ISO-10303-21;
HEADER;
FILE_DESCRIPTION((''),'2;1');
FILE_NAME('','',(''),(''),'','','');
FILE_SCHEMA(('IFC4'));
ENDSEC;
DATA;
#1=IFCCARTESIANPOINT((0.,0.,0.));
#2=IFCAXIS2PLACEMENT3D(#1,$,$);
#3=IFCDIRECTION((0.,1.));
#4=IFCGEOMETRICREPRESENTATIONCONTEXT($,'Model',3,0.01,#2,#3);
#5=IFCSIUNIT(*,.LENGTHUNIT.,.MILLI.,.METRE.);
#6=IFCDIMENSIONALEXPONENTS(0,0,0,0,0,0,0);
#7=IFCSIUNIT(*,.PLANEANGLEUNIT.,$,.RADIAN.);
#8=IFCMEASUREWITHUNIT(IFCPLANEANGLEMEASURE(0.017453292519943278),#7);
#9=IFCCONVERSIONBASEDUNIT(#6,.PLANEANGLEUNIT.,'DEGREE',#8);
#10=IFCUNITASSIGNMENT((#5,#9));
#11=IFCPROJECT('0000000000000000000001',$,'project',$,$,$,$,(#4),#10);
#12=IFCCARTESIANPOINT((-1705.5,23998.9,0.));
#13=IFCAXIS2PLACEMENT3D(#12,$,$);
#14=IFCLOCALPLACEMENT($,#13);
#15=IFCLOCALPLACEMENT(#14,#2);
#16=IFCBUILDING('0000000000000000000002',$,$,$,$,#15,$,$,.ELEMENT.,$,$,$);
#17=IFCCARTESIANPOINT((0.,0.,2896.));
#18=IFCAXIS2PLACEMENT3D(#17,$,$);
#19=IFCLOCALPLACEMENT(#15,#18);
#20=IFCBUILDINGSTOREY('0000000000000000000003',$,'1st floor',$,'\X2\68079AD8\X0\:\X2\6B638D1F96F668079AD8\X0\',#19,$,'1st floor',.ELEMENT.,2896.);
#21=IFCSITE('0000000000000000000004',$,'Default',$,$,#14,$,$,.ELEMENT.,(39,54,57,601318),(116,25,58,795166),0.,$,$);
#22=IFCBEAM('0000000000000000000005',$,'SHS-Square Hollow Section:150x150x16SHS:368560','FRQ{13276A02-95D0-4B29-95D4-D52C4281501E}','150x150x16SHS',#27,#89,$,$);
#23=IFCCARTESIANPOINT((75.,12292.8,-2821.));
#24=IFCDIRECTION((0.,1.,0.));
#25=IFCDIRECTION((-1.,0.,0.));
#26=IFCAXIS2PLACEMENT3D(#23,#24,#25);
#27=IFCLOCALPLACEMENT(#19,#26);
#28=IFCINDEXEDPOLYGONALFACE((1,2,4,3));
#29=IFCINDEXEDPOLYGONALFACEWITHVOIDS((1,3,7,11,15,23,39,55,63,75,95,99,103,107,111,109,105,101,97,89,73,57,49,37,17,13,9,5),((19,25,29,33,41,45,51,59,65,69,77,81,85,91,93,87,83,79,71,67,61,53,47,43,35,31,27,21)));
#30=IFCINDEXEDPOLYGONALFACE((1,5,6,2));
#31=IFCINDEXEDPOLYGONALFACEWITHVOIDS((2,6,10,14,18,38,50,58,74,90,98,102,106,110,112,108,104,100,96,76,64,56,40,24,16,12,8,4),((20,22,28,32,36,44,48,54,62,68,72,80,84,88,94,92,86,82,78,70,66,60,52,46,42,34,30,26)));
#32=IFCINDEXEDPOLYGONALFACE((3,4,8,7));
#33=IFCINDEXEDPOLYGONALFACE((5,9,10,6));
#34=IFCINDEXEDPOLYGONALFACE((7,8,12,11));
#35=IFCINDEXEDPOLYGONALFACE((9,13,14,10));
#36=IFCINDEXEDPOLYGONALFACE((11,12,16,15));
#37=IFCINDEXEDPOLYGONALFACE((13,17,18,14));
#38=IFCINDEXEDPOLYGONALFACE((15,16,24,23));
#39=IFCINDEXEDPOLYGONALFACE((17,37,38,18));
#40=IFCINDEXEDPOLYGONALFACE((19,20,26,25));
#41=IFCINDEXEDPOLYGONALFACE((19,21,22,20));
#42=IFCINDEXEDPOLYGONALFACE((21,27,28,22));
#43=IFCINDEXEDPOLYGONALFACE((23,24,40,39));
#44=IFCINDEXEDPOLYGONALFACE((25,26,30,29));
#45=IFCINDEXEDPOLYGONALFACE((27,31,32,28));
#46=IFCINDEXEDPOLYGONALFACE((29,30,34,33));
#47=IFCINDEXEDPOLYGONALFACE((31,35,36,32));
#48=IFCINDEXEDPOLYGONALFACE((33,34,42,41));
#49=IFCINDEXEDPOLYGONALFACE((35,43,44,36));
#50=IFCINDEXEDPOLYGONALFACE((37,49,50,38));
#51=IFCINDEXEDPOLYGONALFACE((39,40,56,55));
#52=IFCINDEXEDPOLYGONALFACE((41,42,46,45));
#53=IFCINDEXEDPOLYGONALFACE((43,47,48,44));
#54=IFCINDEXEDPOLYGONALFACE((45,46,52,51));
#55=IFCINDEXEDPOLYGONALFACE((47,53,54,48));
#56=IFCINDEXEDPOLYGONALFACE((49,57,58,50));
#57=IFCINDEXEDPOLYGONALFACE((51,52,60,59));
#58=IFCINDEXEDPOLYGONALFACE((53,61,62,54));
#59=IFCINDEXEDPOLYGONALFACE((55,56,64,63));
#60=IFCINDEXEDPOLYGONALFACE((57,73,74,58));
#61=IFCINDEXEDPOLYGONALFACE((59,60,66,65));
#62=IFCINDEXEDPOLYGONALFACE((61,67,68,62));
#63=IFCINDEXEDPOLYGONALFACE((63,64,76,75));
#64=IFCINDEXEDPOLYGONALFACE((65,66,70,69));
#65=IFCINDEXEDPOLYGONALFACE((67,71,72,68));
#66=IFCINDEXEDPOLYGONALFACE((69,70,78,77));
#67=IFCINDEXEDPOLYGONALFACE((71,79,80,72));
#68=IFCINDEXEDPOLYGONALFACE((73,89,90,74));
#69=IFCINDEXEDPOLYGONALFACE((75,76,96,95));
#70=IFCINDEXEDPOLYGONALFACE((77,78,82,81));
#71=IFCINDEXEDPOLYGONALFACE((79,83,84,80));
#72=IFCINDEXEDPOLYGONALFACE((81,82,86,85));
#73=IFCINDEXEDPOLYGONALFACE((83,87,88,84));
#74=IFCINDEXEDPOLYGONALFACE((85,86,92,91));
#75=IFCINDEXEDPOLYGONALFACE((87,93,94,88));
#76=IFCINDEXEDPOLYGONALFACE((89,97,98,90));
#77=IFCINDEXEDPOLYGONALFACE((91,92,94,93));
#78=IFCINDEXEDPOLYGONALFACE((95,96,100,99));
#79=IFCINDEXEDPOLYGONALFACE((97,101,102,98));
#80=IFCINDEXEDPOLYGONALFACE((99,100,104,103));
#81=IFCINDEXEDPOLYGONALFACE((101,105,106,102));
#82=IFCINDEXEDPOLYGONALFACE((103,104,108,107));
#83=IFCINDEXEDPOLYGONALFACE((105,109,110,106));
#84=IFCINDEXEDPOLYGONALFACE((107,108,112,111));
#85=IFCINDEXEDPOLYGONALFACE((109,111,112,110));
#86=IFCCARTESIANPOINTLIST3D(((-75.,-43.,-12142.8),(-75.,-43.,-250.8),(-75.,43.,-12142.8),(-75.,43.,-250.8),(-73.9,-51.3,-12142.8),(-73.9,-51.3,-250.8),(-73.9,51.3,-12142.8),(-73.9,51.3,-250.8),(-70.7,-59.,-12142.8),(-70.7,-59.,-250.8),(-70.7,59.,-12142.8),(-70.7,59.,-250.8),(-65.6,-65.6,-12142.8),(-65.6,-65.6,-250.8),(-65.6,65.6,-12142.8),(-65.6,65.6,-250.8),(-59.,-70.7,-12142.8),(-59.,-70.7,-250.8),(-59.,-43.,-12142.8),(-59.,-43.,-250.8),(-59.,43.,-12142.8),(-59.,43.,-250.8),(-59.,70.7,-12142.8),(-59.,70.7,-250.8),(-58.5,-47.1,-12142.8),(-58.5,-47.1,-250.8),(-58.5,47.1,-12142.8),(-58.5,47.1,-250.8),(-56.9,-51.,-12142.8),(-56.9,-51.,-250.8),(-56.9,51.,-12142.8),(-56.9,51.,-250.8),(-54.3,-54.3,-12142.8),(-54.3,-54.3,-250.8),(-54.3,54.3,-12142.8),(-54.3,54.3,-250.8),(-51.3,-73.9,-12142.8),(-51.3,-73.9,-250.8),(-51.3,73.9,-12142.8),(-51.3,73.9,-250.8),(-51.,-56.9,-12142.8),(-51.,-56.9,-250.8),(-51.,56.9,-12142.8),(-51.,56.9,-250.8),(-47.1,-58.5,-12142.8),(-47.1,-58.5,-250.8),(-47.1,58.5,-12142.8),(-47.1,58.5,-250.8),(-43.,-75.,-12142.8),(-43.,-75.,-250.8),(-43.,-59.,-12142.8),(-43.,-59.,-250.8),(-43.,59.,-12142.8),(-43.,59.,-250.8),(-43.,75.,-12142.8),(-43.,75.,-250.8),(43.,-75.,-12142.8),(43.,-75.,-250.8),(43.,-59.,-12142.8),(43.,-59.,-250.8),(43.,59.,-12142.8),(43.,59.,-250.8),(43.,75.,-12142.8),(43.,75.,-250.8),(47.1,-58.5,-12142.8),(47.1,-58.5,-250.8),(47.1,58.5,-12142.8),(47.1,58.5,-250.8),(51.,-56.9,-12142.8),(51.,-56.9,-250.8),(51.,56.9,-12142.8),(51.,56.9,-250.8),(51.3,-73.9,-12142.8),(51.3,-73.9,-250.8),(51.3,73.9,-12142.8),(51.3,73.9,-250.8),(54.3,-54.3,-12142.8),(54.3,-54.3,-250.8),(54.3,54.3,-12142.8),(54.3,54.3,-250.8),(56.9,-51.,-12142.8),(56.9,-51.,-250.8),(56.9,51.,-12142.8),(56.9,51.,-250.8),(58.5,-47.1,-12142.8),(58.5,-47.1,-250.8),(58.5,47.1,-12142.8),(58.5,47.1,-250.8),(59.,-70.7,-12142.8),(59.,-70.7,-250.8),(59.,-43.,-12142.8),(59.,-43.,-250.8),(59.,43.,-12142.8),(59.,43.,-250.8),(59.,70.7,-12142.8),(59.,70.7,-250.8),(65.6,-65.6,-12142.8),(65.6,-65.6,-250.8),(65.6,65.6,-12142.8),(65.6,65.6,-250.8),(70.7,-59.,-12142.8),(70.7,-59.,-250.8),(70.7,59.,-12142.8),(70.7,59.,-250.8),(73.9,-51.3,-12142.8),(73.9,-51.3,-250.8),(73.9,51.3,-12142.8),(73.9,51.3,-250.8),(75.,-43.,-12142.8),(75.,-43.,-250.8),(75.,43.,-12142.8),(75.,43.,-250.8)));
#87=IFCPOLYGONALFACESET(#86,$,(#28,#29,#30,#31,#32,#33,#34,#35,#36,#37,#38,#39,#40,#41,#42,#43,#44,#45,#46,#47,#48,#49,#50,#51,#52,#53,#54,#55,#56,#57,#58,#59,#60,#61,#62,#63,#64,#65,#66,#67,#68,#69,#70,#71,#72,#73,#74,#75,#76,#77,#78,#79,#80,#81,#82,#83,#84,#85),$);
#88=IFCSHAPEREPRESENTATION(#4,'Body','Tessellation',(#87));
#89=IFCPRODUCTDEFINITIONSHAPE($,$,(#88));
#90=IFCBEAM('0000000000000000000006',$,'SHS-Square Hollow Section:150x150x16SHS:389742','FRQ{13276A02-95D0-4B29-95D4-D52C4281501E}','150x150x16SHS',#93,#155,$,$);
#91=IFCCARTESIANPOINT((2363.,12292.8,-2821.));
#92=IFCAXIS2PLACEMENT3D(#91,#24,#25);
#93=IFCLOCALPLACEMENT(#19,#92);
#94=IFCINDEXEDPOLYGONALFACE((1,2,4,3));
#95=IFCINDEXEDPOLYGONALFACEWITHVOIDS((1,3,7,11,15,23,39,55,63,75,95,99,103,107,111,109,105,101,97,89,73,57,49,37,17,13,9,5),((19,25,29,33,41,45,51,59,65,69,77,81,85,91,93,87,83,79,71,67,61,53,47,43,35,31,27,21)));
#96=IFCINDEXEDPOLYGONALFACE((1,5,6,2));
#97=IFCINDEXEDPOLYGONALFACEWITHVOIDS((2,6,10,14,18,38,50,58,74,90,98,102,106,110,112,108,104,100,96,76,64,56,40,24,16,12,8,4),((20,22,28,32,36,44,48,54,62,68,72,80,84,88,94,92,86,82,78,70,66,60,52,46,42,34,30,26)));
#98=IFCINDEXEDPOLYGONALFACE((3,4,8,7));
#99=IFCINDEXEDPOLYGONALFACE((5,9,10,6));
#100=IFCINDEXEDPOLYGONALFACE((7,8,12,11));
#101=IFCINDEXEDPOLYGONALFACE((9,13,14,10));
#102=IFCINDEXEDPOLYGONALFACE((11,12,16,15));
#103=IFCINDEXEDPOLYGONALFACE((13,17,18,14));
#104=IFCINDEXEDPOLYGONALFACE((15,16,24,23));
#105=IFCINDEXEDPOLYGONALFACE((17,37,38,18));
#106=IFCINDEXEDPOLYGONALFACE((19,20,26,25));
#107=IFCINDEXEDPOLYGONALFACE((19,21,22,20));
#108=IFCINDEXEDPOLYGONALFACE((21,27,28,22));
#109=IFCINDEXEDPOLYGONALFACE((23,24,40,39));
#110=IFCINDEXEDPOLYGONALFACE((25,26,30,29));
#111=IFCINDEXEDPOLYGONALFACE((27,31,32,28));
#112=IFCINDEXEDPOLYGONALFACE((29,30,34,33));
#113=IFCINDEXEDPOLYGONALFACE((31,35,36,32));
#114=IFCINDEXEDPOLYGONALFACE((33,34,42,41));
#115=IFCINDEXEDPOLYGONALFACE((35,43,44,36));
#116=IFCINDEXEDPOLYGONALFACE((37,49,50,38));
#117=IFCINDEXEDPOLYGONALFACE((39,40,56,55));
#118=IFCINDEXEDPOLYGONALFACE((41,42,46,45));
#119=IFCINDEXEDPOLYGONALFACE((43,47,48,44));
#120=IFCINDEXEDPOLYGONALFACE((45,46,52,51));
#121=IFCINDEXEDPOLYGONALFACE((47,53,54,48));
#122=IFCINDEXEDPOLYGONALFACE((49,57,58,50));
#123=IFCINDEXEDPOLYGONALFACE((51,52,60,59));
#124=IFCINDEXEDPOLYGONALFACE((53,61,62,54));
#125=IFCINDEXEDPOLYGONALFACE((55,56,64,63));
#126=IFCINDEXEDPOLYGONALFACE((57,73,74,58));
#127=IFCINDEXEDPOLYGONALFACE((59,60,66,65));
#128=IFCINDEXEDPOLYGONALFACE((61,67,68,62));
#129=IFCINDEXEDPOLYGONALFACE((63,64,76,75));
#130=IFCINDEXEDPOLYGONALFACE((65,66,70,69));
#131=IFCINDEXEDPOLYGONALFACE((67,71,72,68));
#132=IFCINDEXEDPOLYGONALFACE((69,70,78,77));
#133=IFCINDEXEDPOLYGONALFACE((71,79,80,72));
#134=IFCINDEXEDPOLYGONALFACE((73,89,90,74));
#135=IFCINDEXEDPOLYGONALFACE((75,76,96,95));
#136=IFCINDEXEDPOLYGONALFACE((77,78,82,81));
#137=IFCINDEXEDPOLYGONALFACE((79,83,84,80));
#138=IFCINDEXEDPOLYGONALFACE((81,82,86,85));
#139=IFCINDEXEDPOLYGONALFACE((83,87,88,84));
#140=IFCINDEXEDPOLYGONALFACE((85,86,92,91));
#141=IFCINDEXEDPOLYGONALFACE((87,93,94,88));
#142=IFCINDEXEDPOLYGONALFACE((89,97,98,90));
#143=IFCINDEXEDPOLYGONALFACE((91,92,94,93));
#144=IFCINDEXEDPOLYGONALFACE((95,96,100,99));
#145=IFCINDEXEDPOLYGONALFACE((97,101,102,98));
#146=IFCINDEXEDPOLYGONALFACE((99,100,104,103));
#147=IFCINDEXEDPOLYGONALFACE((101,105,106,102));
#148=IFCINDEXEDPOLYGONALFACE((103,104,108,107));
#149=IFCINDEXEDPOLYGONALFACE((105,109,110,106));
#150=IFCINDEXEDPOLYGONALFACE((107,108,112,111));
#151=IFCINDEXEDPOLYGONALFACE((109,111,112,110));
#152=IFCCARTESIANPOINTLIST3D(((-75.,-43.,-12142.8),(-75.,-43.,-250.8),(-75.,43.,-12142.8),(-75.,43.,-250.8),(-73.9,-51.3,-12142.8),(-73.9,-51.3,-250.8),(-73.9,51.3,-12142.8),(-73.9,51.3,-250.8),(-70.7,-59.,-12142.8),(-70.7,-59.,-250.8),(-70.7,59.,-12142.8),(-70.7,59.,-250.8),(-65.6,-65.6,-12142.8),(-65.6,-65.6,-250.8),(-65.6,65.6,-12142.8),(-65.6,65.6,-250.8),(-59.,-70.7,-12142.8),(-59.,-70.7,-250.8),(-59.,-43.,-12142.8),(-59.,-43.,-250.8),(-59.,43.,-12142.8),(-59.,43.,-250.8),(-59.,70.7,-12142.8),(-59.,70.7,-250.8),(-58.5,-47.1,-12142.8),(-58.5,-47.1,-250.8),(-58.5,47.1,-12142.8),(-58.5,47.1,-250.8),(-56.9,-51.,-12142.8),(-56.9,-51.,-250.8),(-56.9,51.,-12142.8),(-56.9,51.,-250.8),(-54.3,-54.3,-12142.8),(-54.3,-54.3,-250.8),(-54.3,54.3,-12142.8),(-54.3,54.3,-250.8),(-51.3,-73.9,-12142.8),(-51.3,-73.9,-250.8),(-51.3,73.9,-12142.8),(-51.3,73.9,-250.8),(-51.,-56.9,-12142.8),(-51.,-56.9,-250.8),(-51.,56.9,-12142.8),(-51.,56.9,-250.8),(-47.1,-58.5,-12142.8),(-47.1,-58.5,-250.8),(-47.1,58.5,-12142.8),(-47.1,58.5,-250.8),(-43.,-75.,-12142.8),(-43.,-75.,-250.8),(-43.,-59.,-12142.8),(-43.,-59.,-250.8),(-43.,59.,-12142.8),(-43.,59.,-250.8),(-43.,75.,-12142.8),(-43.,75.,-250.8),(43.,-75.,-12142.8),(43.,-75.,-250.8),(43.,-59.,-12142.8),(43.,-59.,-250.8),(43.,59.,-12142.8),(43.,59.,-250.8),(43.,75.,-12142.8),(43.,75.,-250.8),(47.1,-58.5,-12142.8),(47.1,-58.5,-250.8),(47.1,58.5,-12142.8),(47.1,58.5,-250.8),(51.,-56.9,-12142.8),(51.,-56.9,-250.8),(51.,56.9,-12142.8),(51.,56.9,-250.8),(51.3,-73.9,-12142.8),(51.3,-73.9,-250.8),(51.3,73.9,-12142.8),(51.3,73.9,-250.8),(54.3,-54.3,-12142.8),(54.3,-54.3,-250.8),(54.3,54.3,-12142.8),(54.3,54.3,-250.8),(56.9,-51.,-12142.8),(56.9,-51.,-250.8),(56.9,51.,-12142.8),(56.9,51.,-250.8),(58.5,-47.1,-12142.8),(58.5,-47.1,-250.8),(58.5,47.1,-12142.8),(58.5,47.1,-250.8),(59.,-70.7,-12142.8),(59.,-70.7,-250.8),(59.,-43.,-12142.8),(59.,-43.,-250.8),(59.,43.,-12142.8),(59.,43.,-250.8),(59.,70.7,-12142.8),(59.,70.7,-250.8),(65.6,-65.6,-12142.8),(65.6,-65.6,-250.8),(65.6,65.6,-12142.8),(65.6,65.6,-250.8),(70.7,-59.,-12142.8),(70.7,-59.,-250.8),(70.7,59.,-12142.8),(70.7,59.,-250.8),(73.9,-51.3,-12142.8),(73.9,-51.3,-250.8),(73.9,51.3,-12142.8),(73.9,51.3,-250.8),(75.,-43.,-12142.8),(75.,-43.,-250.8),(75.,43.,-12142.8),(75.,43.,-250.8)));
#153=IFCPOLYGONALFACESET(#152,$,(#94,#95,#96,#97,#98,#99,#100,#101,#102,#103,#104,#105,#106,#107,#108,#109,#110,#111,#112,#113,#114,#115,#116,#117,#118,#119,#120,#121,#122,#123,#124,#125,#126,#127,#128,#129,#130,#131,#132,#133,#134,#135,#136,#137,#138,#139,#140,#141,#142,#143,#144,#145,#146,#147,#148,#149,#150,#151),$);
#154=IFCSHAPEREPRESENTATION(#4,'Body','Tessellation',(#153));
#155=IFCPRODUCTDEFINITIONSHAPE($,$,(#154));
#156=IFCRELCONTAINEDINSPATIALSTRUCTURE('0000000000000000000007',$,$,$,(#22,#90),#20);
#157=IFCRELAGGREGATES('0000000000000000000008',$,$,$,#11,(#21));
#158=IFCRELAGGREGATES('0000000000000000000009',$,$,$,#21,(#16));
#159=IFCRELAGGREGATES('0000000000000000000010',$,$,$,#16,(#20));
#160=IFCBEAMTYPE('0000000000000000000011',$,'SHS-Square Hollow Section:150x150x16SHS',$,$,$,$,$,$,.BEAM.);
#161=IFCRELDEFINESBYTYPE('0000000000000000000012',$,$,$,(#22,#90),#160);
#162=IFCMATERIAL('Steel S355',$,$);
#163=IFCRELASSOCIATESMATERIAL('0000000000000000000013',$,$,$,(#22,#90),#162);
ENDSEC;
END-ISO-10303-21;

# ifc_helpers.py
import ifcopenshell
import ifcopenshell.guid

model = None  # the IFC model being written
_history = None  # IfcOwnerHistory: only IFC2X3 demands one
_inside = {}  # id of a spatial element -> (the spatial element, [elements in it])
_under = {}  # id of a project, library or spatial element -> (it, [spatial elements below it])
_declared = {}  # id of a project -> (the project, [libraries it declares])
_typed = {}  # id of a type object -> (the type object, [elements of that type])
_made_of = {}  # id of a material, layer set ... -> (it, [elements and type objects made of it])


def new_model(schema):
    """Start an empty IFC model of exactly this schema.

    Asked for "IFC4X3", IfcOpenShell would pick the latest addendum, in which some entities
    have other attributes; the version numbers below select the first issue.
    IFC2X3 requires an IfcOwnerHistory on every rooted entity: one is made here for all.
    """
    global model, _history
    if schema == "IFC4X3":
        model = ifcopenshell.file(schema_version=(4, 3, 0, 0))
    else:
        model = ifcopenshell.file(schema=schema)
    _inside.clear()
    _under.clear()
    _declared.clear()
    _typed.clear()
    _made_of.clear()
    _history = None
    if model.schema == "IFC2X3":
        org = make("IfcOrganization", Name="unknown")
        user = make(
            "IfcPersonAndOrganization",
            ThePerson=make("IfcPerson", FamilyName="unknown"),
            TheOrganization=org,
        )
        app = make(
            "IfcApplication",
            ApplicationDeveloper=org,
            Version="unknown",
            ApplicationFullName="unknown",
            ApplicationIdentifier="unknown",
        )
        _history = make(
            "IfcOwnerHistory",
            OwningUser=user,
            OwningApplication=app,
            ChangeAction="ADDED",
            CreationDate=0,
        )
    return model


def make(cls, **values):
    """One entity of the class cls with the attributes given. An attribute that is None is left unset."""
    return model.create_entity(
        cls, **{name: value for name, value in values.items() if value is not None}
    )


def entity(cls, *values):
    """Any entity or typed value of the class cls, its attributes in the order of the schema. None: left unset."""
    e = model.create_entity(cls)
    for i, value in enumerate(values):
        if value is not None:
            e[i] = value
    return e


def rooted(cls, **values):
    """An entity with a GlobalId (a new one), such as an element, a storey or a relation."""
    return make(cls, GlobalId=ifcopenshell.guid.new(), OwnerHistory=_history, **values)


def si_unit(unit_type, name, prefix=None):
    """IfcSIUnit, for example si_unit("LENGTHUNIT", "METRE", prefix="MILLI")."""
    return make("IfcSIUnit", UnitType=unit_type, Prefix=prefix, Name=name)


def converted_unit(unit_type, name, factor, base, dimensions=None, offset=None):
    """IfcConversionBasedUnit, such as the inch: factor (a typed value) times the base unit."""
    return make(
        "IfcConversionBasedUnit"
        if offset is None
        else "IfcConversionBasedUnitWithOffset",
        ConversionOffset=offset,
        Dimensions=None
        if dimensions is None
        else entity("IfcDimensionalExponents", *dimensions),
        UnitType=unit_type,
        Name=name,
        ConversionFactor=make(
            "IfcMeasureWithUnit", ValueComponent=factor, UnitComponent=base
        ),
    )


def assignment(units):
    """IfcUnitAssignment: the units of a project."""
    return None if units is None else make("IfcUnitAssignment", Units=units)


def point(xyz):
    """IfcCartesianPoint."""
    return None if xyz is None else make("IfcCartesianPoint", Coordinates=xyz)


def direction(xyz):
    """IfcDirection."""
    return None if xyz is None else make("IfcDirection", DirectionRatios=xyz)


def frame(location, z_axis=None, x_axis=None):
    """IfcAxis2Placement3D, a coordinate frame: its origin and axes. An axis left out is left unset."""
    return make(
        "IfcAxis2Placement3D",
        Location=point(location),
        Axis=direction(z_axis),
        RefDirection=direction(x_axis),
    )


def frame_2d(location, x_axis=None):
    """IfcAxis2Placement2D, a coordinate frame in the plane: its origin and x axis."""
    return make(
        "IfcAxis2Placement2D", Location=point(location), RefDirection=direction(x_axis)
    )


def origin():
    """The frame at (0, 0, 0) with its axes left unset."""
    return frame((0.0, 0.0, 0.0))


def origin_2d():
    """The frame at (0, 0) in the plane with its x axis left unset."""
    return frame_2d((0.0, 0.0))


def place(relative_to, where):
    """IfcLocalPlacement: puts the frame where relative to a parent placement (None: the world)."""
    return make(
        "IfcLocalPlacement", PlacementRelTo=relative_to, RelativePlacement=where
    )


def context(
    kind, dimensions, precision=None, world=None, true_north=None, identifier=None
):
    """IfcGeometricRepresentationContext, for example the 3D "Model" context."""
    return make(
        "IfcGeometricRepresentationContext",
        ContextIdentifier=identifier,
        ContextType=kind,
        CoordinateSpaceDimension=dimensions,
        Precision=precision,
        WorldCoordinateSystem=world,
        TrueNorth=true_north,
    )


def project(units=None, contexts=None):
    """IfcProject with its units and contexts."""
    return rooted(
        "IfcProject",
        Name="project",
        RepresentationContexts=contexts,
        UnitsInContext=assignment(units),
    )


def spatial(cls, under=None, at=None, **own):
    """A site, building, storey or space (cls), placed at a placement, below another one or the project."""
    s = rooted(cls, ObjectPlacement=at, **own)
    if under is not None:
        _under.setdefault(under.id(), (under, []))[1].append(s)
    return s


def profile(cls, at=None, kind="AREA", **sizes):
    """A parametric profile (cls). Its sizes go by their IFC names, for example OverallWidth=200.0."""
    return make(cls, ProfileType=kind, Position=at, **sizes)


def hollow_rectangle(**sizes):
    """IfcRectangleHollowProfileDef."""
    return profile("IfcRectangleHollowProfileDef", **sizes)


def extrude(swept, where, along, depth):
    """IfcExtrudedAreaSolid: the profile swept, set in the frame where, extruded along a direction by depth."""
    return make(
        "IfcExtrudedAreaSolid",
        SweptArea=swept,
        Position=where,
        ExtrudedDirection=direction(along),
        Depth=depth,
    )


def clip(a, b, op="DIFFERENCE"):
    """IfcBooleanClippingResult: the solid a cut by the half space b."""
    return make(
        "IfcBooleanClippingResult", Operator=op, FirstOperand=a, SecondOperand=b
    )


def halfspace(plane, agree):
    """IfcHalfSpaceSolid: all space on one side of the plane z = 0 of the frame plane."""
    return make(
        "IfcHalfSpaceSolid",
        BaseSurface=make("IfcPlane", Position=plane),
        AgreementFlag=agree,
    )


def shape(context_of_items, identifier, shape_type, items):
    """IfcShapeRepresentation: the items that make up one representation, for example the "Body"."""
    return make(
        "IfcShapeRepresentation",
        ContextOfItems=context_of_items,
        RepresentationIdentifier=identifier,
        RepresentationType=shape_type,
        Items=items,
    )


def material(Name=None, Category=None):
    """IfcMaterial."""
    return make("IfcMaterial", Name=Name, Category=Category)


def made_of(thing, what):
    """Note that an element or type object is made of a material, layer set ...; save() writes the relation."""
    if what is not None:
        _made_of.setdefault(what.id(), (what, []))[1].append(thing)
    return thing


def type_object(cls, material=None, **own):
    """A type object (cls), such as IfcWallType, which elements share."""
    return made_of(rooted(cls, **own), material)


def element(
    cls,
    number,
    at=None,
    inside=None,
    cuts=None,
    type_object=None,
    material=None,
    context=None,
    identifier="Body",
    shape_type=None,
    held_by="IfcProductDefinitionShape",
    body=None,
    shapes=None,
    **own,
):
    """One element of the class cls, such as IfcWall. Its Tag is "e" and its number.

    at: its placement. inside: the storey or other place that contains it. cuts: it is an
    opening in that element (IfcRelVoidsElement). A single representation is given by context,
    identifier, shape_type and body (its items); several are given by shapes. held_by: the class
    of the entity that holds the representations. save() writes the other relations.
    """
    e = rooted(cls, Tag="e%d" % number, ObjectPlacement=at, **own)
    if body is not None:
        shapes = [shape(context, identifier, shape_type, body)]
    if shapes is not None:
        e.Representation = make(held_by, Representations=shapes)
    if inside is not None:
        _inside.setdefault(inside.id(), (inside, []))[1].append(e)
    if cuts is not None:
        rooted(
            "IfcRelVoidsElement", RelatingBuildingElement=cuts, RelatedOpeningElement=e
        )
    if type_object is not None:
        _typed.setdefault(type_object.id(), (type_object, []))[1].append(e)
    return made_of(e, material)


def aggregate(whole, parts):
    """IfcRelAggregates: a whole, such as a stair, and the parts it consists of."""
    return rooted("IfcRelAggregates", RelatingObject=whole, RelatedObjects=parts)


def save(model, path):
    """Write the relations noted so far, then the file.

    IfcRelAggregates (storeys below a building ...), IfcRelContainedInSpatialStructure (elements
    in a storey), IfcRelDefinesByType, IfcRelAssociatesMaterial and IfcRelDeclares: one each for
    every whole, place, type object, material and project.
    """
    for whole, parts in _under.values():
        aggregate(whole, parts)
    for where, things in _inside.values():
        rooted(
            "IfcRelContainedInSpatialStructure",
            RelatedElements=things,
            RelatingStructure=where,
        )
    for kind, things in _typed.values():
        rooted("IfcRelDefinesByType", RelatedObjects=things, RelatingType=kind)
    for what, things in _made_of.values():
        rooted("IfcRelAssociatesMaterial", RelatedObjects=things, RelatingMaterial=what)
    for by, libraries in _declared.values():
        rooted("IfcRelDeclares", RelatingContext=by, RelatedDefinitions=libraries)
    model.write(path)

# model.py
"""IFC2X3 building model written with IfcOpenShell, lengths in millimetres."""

from ifc_helpers import new_model, entity, si_unit, converted_unit, direction, frame, origin, origin_2d, place, context, project, spatial, hollow_rectangle, extrude, clip, halfspace, material, type_object, element, save


model = new_model("IFC2X3")

# Units and contexts
model_context = context("Model", 3, precision=0.01, world=origin(), true_north=direction((0.0, 1.0)))
ifc_project = project(units=[si_unit("LENGTHUNIT", "METRE", prefix="MILLI"), converted_unit("PLANEANGLEUNIT", "DEGREE", entity("IfcPlaneAngleMeasure", 0.017453292519943278), si_unit("PLANEANGLEUNIT", "RADIAN"), dimensions=[0, 0, 0, 0, 0, 0, 0])], contexts=[model_context])

# Site, building, storey
site_placement = place(None, frame((-1705.5, 23998.9, 0.0)))
site = spatial("IfcSite", under=ifc_project, at=site_placement, Name="Default", CompositionType="ELEMENT", RefLatitude=(39, 54, 57, 601318), RefLongitude=(116, 25, 58, 795166), RefElevation=0.0)
building_placement = place(site_placement, origin())
building = spatial("IfcBuilding", under=site, at=building_placement, CompositionType="ELEMENT")
storey_placement = place(building_placement, frame((0.0, 0.0, 2896.0)))
storey = spatial("IfcBuildingStorey", under=building, at=storey_placement, Name="1st floor", ObjectType="标高:正负零标高", LongName="1st floor", CompositionType="ELEMENT", Elevation=2896.0)

# Shared definitions
ifc_material_1 = material(Name="Steel S355")

# Shared definitions
beam_type_1 = type_object("IfcBeamType", Name="SHS-Square Hollow Section:150x150x16SHS", PredefinedType="BEAM")

# Beams
beam_1_placement = place(storey_placement, frame((75.0, 12292.8, -2821.0), z_axis=(0.0, 1.0, 0.0), x_axis=(-1.0, 0.0, 0.0)))
element("IfcBeam", 1, at=beam_1_placement, inside=storey, type_object=beam_type_1, material=ifc_material_1, Name="SHS-Square Hollow Section:150x150x16SHS:368560", Description="FRQ{13276A02-95D0-4B29-95D4-D52C4281501E}", ObjectType="150x150x16SHS", context=model_context, shape_type="Clipping", body=[
    clip(clip(extrude(hollow_rectangle(XDim=150.0, YDim=150.0, WallThickness=16.0, InnerFilletRadius=16.0, OuterFilletRadius=32.0, at=origin_2d()), origin(), (0.0, 0.0, -1.0), 12398.9), halfspace(frame((75.0, -75.0, -250.8), z_axis=(0.0, 0.0, -1.0), x_axis=(-1.0, 0.0, 0.0)), True)), halfspace(frame((75.0, -75.0, -12142.8), z_axis=(0.0, 0.0, 1.0), x_axis=(1.0, 0.0, 0.0)), True)),
])
beam_2_placement = place(storey_placement, frame((2363.0, 12292.8, -2821.0), z_axis=(0.0, 1.0, 0.0), x_axis=(-1.0, 0.0, 0.0)))
element("IfcBeam", 2, at=beam_2_placement, inside=storey, type_object=beam_type_1, material=ifc_material_1, Name="SHS-Square Hollow Section:150x150x16SHS:389742", Description="FRQ{13276A02-95D0-4B29-95D4-D52C4281501E}", ObjectType="150x150x16SHS", context=model_context, shape_type="Clipping", body=[
    clip(clip(extrude(hollow_rectangle(XDim=150.0, YDim=150.0, WallThickness=16.0, InnerFilletRadius=16.0, OuterFilletRadius=32.0, at=origin_2d()), origin(), (0.0, 0.0, -1.0), 12398.9), halfspace(frame((2363.0, -75.0, -250.8), z_axis=(0.0, 0.0, -1.0), x_axis=(-1.0, 0.0, 0.0)), True)), halfspace(frame((2363.0, -75.0, -12142.8), z_axis=(0.0, 0.0, 1.0), x_axis=(1.0, 0.0, 0.0)), True)),
])

save(model, "model.ifc")
